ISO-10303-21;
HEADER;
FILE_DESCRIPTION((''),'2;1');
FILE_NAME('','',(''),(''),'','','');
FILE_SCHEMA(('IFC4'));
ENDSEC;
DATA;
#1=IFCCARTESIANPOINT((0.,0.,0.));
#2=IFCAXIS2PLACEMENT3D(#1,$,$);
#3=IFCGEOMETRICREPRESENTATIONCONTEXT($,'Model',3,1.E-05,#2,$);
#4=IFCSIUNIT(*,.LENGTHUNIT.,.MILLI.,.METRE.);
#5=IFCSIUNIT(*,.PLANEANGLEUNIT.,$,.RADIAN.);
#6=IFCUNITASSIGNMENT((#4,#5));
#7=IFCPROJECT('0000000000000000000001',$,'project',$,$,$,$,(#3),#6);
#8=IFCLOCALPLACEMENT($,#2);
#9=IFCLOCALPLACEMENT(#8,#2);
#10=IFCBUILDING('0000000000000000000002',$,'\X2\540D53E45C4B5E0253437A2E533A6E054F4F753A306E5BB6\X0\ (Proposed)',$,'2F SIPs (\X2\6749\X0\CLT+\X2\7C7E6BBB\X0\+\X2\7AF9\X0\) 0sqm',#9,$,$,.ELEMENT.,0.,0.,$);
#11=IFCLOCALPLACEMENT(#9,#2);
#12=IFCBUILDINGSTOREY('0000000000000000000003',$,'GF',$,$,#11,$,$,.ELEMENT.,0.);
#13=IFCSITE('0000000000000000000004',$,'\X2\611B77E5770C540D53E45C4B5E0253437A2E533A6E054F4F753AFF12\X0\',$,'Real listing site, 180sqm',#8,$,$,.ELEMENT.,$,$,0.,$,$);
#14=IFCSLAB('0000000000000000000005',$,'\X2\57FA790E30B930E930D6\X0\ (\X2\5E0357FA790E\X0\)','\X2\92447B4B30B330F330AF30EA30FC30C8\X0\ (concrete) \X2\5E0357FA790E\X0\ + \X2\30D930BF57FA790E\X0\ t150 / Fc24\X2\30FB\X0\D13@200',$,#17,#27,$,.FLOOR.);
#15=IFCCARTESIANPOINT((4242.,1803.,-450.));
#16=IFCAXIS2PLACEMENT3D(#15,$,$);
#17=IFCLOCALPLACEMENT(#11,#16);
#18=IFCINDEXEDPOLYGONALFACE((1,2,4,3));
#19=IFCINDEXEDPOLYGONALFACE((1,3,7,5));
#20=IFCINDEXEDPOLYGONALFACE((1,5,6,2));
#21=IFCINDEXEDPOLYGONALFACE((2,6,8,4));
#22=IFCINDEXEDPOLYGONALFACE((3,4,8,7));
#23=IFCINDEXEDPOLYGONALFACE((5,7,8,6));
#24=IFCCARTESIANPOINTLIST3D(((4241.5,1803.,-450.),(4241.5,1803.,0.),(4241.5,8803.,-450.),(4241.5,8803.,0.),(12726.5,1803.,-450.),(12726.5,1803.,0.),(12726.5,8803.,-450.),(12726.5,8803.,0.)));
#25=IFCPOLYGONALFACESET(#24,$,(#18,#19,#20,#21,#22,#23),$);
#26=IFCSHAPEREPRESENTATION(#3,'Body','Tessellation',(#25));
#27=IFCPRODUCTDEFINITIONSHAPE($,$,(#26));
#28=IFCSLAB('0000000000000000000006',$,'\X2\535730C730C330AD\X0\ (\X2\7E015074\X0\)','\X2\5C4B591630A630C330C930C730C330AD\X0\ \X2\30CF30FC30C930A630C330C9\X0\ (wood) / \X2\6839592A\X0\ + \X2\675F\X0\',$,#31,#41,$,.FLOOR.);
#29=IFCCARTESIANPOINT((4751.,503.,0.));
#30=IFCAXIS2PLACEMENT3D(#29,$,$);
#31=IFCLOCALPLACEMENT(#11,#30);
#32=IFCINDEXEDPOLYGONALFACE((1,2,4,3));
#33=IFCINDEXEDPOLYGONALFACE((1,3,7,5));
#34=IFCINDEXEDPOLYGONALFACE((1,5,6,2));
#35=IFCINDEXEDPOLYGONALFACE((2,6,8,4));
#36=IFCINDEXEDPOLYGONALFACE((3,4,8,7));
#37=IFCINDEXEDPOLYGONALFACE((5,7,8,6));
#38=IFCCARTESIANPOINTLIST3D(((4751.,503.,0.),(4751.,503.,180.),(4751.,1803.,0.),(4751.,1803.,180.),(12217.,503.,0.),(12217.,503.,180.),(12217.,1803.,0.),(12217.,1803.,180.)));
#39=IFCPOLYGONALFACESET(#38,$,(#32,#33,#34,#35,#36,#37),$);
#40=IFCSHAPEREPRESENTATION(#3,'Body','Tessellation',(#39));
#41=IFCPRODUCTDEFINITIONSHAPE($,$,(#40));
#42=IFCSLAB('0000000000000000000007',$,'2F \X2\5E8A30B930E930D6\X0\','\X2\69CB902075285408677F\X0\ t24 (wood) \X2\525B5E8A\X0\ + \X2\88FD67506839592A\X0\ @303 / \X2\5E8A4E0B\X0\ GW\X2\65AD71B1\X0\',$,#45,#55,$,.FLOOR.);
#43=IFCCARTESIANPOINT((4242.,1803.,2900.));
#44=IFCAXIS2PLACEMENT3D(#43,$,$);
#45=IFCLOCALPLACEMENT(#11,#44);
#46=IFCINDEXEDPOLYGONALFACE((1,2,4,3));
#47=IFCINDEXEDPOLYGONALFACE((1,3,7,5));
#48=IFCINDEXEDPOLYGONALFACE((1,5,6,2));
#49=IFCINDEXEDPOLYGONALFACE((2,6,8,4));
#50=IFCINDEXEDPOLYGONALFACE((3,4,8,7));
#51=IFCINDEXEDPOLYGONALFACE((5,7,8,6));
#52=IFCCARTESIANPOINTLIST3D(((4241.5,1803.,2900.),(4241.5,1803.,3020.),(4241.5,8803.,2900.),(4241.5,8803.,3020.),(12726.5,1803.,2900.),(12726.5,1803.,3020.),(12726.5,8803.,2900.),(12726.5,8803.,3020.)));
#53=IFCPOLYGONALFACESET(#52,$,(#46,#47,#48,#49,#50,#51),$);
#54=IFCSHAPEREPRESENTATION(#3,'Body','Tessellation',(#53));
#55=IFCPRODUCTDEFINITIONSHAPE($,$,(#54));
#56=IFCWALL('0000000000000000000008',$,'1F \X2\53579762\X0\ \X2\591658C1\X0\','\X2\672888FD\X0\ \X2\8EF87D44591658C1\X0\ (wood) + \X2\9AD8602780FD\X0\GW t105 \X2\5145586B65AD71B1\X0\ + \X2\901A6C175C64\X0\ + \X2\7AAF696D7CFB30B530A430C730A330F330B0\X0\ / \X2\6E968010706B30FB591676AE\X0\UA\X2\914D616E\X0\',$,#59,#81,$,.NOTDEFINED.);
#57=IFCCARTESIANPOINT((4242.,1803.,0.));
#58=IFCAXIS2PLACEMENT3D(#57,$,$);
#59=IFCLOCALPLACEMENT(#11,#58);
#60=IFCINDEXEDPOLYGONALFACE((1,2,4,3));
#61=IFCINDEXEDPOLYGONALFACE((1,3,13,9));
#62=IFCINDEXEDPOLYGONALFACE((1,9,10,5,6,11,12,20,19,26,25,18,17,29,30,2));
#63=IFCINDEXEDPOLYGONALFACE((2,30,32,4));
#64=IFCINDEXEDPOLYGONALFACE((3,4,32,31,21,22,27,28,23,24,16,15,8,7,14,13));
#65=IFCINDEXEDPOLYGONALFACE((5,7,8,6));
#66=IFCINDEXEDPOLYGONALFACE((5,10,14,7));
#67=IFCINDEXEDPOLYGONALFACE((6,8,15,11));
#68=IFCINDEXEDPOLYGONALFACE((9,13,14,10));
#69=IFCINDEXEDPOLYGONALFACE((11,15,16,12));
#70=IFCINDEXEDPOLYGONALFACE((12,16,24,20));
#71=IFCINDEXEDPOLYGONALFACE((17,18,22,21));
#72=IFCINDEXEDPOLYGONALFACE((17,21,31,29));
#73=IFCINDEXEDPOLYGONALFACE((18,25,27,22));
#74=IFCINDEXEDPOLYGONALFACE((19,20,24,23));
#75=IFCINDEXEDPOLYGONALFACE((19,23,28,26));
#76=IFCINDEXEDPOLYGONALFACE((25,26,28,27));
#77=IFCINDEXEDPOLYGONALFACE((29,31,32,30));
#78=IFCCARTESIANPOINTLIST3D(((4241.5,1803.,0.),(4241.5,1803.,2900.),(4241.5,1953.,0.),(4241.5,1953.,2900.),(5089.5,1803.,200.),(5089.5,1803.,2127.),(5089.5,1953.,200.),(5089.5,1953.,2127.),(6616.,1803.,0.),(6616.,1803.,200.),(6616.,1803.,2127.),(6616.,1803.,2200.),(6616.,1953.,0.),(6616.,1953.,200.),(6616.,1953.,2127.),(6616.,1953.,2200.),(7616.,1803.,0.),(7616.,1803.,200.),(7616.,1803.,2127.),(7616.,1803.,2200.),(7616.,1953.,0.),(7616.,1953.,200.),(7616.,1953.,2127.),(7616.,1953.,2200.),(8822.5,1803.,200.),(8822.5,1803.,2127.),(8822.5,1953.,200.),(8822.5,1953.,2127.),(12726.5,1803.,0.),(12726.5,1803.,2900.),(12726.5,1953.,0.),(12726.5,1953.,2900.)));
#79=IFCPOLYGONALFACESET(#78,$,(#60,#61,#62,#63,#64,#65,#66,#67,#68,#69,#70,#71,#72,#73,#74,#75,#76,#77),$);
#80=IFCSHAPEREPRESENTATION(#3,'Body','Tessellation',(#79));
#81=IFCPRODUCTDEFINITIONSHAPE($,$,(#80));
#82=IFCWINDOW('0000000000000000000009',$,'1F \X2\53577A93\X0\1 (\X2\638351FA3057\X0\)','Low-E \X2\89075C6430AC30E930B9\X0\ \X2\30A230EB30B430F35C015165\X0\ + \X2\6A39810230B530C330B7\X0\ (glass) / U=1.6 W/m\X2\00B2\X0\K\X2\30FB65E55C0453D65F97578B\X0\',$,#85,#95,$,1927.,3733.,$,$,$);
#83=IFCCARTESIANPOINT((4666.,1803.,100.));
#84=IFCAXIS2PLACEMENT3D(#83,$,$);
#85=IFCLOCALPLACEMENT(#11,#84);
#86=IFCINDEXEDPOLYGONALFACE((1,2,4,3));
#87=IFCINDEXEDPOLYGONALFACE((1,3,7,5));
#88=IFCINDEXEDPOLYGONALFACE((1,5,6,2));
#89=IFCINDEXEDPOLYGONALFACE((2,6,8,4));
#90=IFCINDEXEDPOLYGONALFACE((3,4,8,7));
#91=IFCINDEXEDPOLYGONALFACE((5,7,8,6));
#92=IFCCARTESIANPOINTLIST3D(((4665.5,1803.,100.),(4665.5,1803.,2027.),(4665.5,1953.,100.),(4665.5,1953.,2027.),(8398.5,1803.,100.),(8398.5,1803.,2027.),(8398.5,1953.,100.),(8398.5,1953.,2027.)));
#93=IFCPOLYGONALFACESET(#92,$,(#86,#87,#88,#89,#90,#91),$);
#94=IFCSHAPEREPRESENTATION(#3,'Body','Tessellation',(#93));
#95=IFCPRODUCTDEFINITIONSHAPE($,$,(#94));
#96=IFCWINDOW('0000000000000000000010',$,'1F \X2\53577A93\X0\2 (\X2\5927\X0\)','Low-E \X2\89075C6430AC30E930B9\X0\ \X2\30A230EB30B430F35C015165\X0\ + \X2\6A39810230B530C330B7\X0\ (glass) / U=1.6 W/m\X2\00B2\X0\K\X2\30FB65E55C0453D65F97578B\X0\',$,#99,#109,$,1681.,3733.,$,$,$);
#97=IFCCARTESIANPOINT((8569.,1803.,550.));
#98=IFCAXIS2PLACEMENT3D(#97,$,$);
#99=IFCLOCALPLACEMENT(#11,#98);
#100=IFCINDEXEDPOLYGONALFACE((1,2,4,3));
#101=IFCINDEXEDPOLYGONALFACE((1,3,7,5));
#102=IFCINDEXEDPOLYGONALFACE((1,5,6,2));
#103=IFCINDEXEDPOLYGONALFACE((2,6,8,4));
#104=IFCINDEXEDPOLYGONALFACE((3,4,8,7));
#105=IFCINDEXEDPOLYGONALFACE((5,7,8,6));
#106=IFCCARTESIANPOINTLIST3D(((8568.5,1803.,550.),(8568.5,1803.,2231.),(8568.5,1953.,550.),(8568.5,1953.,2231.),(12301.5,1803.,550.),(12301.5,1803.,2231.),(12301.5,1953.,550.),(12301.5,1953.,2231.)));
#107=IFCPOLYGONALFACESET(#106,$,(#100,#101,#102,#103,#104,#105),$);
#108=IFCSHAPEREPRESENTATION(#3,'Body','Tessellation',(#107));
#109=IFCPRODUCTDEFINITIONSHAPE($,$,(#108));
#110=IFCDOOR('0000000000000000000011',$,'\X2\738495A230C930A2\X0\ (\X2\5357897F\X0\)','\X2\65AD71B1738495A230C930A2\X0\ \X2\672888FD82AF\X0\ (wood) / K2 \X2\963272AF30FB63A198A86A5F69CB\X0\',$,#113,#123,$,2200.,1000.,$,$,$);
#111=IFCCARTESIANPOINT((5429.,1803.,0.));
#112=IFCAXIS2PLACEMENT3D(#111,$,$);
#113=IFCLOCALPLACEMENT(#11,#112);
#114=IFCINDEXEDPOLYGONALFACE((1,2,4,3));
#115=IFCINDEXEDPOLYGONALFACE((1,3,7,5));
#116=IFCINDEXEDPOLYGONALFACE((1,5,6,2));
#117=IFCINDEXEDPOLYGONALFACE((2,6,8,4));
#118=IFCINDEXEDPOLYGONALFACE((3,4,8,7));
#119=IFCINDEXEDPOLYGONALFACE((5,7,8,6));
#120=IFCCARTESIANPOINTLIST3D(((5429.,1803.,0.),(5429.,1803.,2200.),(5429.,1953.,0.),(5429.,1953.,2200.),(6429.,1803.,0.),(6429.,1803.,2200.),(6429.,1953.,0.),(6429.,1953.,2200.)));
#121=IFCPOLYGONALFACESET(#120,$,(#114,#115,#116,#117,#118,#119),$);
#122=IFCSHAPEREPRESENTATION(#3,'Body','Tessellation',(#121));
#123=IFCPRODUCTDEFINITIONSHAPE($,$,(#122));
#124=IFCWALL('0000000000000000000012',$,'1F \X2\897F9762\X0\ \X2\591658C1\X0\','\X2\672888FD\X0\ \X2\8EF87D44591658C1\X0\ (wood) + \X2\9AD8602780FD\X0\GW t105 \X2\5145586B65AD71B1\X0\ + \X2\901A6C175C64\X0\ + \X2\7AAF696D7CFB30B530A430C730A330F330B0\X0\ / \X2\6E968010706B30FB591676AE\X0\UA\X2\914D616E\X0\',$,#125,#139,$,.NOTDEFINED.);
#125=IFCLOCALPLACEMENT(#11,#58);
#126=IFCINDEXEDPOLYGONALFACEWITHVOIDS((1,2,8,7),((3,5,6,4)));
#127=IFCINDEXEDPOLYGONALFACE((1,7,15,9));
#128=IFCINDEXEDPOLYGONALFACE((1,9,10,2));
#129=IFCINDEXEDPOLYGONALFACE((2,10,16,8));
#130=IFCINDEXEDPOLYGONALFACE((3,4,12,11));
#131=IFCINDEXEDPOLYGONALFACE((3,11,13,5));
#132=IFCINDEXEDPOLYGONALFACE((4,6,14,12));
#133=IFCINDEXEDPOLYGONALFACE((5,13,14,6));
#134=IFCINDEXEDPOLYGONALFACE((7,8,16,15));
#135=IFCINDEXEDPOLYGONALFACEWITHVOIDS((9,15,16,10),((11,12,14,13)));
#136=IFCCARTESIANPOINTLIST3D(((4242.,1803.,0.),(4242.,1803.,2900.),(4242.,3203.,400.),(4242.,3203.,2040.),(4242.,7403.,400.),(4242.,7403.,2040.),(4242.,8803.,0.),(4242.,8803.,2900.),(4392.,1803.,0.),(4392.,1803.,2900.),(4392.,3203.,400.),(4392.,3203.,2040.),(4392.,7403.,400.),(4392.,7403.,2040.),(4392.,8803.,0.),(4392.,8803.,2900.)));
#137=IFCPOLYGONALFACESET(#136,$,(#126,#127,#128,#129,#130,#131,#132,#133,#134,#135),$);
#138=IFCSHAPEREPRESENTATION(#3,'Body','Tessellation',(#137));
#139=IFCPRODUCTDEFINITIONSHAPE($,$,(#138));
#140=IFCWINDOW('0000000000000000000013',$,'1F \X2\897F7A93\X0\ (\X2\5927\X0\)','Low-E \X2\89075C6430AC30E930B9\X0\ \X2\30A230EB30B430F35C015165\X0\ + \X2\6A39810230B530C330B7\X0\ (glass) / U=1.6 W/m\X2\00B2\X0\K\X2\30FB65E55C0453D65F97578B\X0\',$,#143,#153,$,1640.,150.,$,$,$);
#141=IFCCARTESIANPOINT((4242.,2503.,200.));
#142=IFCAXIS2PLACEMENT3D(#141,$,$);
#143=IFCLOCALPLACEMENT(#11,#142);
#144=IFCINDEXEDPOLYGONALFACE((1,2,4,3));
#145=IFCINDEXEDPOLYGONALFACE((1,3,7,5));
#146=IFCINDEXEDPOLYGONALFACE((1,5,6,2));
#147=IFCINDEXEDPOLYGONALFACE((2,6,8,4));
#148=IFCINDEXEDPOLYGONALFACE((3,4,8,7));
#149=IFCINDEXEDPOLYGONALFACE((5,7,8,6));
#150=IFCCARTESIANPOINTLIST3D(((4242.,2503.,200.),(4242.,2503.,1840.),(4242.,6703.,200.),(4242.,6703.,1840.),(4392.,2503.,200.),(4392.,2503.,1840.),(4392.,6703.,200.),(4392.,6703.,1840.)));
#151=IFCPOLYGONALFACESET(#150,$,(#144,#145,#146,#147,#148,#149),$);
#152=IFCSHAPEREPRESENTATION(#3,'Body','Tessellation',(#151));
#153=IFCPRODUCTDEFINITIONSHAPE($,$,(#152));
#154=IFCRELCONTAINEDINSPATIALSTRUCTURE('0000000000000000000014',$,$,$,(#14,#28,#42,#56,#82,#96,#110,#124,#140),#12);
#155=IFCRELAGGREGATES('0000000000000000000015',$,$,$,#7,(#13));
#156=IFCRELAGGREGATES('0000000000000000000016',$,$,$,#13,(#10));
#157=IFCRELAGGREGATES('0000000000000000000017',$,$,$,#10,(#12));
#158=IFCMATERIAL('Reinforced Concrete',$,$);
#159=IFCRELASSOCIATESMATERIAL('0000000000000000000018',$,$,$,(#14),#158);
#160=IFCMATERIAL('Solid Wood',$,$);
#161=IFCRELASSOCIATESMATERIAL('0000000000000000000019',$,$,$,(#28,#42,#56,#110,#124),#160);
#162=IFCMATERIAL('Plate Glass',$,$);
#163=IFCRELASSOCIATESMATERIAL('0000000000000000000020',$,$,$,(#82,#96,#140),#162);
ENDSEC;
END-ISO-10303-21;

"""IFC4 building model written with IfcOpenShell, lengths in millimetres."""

from ifc_helpers import new_model, si_unit, frame, frame_2d, origin, place, context, project, spatial, rectangle, extrude, material, element, fill, save


model = new_model("IFC4")

# Units and contexts
model_context = context("Model", 3, precision=1e-05, world=origin())
ifc_project = project(units=[si_unit("LENGTHUNIT", "METRE", prefix="MILLI"), si_unit("PLANEANGLEUNIT", "RADIAN")], contexts=[model_context])

# Site, building, storey
site_placement = place(None, origin())
site = spatial("IfcSite", under=ifc_project, at=site_placement, Name="愛知県名古屋市千種区清住町２", ObjectType="Real listing site, 180sqm", CompositionType="ELEMENT", RefElevation=0.0)
building_placement = place(site_placement, origin())
building = spatial("IfcBuilding", under=site, at=building_placement, Name="名古屋市千種区清住町の家 (Proposed)", ObjectType="2F SIPs (杉CLT+籾殻+竹) 0sqm", CompositionType="ELEMENT", ElevationOfRefHeight=0.0, ElevationOfTerrain=0.0)
storey_placement = place(building_placement, origin())
storey = spatial("IfcBuildingStorey", under=building, at=storey_placement, Name="GF", CompositionType="ELEMENT", Elevation=0.0)

# Slabs
ifc_material_1 = material(Name="Reinforced Concrete")
slab_1_placement = place(storey_placement, frame((4242.0, 1803.0, -450.0)))
element("IfcSlab", 1, at=slab_1_placement, inside=storey, material=ifc_material_1, Name="基礎スラブ (布基礎)", Description="鉄筋コンクリート (concrete) 布基礎 + ベタ基礎 t150 / Fc24・D13@200", PredefinedType="FLOOR", context=model_context, shape_type="SweptSolid", body=[
    extrude(rectangle(XDim=8485.0, YDim=7000.0, at=frame_2d((4242.0, 3500.0))), frame((4242.0, 1803.0, -450.0)), (0.0, 0.0, 1.0), 450.0),
])
ifc_material_2 = material(Name="Solid Wood")
slab_2_placement = place(storey_placement, frame((4751.0, 503.0, 0.0)))
element("IfcSlab", 2, at=slab_2_placement, inside=storey, material=ifc_material_2, Name="南デッキ (縁側)", Description="屋外ウッドデッキ ハードウッド (wood) / 根太 + 束", PredefinedType="FLOOR", context=model_context, shape_type="SweptSolid", body=[
    extrude(rectangle(XDim=7466.0, YDim=1300.0, at=frame_2d((3733.0, 650.0))), frame((4751.0, 503.0, 0.0)), (0.0, 0.0, 1.0), 180.0),
])
slab_3_placement = place(storey_placement, frame((4242.0, 1803.0, 2900.0)))
element("IfcSlab", 3, at=slab_3_placement, inside=storey, material=ifc_material_2, Name="2F 床スラブ", Description="構造用合板 t24 (wood) 剛床 + 製材根太 @303 / 床下 GW断熱", PredefinedType="FLOOR", context=model_context, shape_type="SweptSolid", body=[
    extrude(rectangle(XDim=8485.0, YDim=7000.0, at=frame_2d((4242.0, 3500.0))), frame((4242.0, 1803.0, 2900.0)), (0.0, 0.0, 1.0), 120.0),
])

# Wall, openings, windows, door
wall_1_placement = place(storey_placement, frame((4242.0, 1803.0, 0.0)))
wall_1 = element("IfcWall", 4, at=wall_1_placement, inside=storey, material=ifc_material_2, Name="1F 南面 外壁", Description="木製 軸組外壁 (wood) + 高性能GW t105 充填断熱 + 通気層 + 窯業系サイディング / 準耐火・外皮UA配慮", PredefinedType="NOTDEFINED", context=model_context, shape_type="SweptSolid", body=[
    extrude(rectangle(XDim=8485.0, YDim=150.0, at=frame_2d((4242.0, 75.0))), frame((4242.0, 1803.0, 0.0)), (0.0, 0.0, 1.0), 2900.0),
])
opening_1_placement = place(storey_placement, frame((4666.0, 1803.0, 100.0)))
opening_1 = element("IfcOpeningElement", 5, at=opening_1_placement, cuts=wall_1, PredefinedType="NOTDEFINED", context=model_context, shape_type="SweptSolid", body=[
    extrude(rectangle(XDim=3733.0, YDim=150.0, at=frame_2d((1866.0, 75.0))), frame((4666.0, 1803.0, 100.0)), (0.0, 0.0, 1.0), 1927.0),
])
opening_2_placement = place(storey_placement, frame((8569.0, 1803.0, 550.0)))
opening_2 = element("IfcOpeningElement", 6, at=opening_2_placement, cuts=wall_1, PredefinedType="NOTDEFINED", context=model_context, shape_type="SweptSolid", body=[
    extrude(rectangle(XDim=3733.0, YDim=150.0, at=frame_2d((1866.0, 75.0))), frame((8569.0, 1803.0, 550.0)), (0.0, 0.0, 1.0), 1681.0),
])
opening_3_placement = place(storey_placement, frame((5429.0, 1803.0, 0.0)))
opening_3 = element("IfcOpeningElement", 7, at=opening_3_placement, cuts=wall_1, PredefinedType="NOTDEFINED", context=model_context, shape_type="SweptSolid", body=[
    extrude(rectangle(XDim=1000.0, YDim=150.0, at=frame_2d((500.0, 75.0))), frame((5429.0, 1803.0, 0.0)), (0.0, 0.0, 1.0), 2200.0),
])
ifc_material_3 = material(Name="Plate Glass")
window_1_placement = place(storey_placement, frame((4666.0, 1803.0, 100.0)))
window_1 = element("IfcWindow", 8, at=window_1_placement, inside=storey, material=ifc_material_3, Name="1F 南窓1 (掃出し)", Description="Low-E 複層ガラス アルゴン封入 + 樹脂サッシ (glass) / U=1.6 W/m²K・日射取得型", OverallHeight=1927.0, OverallWidth=3733.0, context=model_context, shape_type="SweptSolid", body=[
    extrude(rectangle(XDim=3733.0, YDim=150.0, at=frame_2d((1866.0, 75.0))), frame((4666.0, 1803.0, 100.0)), (0.0, 0.0, 1.0), 1927.0),
])
fill(opening_1, window_1)
window_2_placement = place(storey_placement, frame((8569.0, 1803.0, 550.0)))
window_2 = element("IfcWindow", 9, at=window_2_placement, inside=storey, material=ifc_material_3, Name="1F 南窓2 (大)", Description="Low-E 複層ガラス アルゴン封入 + 樹脂サッシ (glass) / U=1.6 W/m²K・日射取得型", OverallHeight=1681.0, OverallWidth=3733.0, context=model_context, shape_type="SweptSolid", body=[
    extrude(rectangle(XDim=3733.0, YDim=150.0, at=frame_2d((1866.0, 75.0))), frame((8569.0, 1803.0, 550.0)), (0.0, 0.0, 1.0), 1681.0),
])
fill(opening_2, window_2)
door_placement = place(storey_placement, frame((5429.0, 1803.0, 0.0)))
door = element("IfcDoor", 10, at=door_placement, inside=storey, material=ifc_material_2, Name="玄関ドア (南西)", Description="断熱玄関ドア 木製芯 (wood) / K2 防犯・採風機構", OverallHeight=2200.0, OverallWidth=1000.0, context=model_context, shape_type="SweptSolid", body=[
    extrude(rectangle(XDim=1000.0, YDim=150.0, at=frame_2d((500.0, 75.0))), frame((5429.0, 1803.0, 0.0)), (0.0, 0.0, 1.0), 2200.0),
])
fill(opening_3, door)

# Wall, opening, window
wall_2_placement = place(storey_placement, frame((4242.0, 1803.0, 0.0)))
wall_2 = element("IfcWall", 11, at=wall_2_placement, inside=storey, material=ifc_material_2, Name="1F 西面 外壁", Description="木製 軸組外壁 (wood) + 高性能GW t105 充填断熱 + 通気層 + 窯業系サイディング / 準耐火・外皮UA配慮", PredefinedType="NOTDEFINED", context=model_context, shape_type="SweptSolid", body=[
    extrude(rectangle(XDim=150.0, YDim=7000.0, at=frame_2d((75.0, 3500.0))), frame((4242.0, 1803.0, 0.0)), (0.0, 0.0, 1.0), 2900.0),
])
opening_4_placement = place(storey_placement, frame((4242.0, 2503.0, 200.0)))
opening_4 = element("IfcOpeningElement", 12, at=opening_4_placement, cuts=wall_2, PredefinedType="NOTDEFINED", context=model_context, shape_type="SweptSolid", body=[
    extrude(rectangle(XDim=150.0, YDim=4200.0, at=frame_2d((75.0, 2100.0))), frame((4242.0, 2503.0, 200.0)), (0.0, 0.0, 1.0), 1640.0),
])
window_3_placement = place(storey_placement, frame((4242.0, 2503.0, 200.0)))
window_3 = element("IfcWindow", 13, at=window_3_placement, inside=storey, material=ifc_material_3, Name="1F 西窓 (大)", Description="Low-E 複層ガラス アルゴン封入 + 樹脂サッシ (glass) / U=1.6 W/m²K・日射取得型", OverallHeight=1640.0, OverallWidth=150.0, context=model_context, shape_type="SweptSolid", body=[
    extrude(rectangle(XDim=150.0, YDim=4200.0, at=frame_2d((75.0, 2100.0))), frame((4242.0, 2503.0, 200.0)), (0.0, 0.0, 1.0), 1640.0),
])
fill(opening_4, window_3)

save(model, "model.ifc")
